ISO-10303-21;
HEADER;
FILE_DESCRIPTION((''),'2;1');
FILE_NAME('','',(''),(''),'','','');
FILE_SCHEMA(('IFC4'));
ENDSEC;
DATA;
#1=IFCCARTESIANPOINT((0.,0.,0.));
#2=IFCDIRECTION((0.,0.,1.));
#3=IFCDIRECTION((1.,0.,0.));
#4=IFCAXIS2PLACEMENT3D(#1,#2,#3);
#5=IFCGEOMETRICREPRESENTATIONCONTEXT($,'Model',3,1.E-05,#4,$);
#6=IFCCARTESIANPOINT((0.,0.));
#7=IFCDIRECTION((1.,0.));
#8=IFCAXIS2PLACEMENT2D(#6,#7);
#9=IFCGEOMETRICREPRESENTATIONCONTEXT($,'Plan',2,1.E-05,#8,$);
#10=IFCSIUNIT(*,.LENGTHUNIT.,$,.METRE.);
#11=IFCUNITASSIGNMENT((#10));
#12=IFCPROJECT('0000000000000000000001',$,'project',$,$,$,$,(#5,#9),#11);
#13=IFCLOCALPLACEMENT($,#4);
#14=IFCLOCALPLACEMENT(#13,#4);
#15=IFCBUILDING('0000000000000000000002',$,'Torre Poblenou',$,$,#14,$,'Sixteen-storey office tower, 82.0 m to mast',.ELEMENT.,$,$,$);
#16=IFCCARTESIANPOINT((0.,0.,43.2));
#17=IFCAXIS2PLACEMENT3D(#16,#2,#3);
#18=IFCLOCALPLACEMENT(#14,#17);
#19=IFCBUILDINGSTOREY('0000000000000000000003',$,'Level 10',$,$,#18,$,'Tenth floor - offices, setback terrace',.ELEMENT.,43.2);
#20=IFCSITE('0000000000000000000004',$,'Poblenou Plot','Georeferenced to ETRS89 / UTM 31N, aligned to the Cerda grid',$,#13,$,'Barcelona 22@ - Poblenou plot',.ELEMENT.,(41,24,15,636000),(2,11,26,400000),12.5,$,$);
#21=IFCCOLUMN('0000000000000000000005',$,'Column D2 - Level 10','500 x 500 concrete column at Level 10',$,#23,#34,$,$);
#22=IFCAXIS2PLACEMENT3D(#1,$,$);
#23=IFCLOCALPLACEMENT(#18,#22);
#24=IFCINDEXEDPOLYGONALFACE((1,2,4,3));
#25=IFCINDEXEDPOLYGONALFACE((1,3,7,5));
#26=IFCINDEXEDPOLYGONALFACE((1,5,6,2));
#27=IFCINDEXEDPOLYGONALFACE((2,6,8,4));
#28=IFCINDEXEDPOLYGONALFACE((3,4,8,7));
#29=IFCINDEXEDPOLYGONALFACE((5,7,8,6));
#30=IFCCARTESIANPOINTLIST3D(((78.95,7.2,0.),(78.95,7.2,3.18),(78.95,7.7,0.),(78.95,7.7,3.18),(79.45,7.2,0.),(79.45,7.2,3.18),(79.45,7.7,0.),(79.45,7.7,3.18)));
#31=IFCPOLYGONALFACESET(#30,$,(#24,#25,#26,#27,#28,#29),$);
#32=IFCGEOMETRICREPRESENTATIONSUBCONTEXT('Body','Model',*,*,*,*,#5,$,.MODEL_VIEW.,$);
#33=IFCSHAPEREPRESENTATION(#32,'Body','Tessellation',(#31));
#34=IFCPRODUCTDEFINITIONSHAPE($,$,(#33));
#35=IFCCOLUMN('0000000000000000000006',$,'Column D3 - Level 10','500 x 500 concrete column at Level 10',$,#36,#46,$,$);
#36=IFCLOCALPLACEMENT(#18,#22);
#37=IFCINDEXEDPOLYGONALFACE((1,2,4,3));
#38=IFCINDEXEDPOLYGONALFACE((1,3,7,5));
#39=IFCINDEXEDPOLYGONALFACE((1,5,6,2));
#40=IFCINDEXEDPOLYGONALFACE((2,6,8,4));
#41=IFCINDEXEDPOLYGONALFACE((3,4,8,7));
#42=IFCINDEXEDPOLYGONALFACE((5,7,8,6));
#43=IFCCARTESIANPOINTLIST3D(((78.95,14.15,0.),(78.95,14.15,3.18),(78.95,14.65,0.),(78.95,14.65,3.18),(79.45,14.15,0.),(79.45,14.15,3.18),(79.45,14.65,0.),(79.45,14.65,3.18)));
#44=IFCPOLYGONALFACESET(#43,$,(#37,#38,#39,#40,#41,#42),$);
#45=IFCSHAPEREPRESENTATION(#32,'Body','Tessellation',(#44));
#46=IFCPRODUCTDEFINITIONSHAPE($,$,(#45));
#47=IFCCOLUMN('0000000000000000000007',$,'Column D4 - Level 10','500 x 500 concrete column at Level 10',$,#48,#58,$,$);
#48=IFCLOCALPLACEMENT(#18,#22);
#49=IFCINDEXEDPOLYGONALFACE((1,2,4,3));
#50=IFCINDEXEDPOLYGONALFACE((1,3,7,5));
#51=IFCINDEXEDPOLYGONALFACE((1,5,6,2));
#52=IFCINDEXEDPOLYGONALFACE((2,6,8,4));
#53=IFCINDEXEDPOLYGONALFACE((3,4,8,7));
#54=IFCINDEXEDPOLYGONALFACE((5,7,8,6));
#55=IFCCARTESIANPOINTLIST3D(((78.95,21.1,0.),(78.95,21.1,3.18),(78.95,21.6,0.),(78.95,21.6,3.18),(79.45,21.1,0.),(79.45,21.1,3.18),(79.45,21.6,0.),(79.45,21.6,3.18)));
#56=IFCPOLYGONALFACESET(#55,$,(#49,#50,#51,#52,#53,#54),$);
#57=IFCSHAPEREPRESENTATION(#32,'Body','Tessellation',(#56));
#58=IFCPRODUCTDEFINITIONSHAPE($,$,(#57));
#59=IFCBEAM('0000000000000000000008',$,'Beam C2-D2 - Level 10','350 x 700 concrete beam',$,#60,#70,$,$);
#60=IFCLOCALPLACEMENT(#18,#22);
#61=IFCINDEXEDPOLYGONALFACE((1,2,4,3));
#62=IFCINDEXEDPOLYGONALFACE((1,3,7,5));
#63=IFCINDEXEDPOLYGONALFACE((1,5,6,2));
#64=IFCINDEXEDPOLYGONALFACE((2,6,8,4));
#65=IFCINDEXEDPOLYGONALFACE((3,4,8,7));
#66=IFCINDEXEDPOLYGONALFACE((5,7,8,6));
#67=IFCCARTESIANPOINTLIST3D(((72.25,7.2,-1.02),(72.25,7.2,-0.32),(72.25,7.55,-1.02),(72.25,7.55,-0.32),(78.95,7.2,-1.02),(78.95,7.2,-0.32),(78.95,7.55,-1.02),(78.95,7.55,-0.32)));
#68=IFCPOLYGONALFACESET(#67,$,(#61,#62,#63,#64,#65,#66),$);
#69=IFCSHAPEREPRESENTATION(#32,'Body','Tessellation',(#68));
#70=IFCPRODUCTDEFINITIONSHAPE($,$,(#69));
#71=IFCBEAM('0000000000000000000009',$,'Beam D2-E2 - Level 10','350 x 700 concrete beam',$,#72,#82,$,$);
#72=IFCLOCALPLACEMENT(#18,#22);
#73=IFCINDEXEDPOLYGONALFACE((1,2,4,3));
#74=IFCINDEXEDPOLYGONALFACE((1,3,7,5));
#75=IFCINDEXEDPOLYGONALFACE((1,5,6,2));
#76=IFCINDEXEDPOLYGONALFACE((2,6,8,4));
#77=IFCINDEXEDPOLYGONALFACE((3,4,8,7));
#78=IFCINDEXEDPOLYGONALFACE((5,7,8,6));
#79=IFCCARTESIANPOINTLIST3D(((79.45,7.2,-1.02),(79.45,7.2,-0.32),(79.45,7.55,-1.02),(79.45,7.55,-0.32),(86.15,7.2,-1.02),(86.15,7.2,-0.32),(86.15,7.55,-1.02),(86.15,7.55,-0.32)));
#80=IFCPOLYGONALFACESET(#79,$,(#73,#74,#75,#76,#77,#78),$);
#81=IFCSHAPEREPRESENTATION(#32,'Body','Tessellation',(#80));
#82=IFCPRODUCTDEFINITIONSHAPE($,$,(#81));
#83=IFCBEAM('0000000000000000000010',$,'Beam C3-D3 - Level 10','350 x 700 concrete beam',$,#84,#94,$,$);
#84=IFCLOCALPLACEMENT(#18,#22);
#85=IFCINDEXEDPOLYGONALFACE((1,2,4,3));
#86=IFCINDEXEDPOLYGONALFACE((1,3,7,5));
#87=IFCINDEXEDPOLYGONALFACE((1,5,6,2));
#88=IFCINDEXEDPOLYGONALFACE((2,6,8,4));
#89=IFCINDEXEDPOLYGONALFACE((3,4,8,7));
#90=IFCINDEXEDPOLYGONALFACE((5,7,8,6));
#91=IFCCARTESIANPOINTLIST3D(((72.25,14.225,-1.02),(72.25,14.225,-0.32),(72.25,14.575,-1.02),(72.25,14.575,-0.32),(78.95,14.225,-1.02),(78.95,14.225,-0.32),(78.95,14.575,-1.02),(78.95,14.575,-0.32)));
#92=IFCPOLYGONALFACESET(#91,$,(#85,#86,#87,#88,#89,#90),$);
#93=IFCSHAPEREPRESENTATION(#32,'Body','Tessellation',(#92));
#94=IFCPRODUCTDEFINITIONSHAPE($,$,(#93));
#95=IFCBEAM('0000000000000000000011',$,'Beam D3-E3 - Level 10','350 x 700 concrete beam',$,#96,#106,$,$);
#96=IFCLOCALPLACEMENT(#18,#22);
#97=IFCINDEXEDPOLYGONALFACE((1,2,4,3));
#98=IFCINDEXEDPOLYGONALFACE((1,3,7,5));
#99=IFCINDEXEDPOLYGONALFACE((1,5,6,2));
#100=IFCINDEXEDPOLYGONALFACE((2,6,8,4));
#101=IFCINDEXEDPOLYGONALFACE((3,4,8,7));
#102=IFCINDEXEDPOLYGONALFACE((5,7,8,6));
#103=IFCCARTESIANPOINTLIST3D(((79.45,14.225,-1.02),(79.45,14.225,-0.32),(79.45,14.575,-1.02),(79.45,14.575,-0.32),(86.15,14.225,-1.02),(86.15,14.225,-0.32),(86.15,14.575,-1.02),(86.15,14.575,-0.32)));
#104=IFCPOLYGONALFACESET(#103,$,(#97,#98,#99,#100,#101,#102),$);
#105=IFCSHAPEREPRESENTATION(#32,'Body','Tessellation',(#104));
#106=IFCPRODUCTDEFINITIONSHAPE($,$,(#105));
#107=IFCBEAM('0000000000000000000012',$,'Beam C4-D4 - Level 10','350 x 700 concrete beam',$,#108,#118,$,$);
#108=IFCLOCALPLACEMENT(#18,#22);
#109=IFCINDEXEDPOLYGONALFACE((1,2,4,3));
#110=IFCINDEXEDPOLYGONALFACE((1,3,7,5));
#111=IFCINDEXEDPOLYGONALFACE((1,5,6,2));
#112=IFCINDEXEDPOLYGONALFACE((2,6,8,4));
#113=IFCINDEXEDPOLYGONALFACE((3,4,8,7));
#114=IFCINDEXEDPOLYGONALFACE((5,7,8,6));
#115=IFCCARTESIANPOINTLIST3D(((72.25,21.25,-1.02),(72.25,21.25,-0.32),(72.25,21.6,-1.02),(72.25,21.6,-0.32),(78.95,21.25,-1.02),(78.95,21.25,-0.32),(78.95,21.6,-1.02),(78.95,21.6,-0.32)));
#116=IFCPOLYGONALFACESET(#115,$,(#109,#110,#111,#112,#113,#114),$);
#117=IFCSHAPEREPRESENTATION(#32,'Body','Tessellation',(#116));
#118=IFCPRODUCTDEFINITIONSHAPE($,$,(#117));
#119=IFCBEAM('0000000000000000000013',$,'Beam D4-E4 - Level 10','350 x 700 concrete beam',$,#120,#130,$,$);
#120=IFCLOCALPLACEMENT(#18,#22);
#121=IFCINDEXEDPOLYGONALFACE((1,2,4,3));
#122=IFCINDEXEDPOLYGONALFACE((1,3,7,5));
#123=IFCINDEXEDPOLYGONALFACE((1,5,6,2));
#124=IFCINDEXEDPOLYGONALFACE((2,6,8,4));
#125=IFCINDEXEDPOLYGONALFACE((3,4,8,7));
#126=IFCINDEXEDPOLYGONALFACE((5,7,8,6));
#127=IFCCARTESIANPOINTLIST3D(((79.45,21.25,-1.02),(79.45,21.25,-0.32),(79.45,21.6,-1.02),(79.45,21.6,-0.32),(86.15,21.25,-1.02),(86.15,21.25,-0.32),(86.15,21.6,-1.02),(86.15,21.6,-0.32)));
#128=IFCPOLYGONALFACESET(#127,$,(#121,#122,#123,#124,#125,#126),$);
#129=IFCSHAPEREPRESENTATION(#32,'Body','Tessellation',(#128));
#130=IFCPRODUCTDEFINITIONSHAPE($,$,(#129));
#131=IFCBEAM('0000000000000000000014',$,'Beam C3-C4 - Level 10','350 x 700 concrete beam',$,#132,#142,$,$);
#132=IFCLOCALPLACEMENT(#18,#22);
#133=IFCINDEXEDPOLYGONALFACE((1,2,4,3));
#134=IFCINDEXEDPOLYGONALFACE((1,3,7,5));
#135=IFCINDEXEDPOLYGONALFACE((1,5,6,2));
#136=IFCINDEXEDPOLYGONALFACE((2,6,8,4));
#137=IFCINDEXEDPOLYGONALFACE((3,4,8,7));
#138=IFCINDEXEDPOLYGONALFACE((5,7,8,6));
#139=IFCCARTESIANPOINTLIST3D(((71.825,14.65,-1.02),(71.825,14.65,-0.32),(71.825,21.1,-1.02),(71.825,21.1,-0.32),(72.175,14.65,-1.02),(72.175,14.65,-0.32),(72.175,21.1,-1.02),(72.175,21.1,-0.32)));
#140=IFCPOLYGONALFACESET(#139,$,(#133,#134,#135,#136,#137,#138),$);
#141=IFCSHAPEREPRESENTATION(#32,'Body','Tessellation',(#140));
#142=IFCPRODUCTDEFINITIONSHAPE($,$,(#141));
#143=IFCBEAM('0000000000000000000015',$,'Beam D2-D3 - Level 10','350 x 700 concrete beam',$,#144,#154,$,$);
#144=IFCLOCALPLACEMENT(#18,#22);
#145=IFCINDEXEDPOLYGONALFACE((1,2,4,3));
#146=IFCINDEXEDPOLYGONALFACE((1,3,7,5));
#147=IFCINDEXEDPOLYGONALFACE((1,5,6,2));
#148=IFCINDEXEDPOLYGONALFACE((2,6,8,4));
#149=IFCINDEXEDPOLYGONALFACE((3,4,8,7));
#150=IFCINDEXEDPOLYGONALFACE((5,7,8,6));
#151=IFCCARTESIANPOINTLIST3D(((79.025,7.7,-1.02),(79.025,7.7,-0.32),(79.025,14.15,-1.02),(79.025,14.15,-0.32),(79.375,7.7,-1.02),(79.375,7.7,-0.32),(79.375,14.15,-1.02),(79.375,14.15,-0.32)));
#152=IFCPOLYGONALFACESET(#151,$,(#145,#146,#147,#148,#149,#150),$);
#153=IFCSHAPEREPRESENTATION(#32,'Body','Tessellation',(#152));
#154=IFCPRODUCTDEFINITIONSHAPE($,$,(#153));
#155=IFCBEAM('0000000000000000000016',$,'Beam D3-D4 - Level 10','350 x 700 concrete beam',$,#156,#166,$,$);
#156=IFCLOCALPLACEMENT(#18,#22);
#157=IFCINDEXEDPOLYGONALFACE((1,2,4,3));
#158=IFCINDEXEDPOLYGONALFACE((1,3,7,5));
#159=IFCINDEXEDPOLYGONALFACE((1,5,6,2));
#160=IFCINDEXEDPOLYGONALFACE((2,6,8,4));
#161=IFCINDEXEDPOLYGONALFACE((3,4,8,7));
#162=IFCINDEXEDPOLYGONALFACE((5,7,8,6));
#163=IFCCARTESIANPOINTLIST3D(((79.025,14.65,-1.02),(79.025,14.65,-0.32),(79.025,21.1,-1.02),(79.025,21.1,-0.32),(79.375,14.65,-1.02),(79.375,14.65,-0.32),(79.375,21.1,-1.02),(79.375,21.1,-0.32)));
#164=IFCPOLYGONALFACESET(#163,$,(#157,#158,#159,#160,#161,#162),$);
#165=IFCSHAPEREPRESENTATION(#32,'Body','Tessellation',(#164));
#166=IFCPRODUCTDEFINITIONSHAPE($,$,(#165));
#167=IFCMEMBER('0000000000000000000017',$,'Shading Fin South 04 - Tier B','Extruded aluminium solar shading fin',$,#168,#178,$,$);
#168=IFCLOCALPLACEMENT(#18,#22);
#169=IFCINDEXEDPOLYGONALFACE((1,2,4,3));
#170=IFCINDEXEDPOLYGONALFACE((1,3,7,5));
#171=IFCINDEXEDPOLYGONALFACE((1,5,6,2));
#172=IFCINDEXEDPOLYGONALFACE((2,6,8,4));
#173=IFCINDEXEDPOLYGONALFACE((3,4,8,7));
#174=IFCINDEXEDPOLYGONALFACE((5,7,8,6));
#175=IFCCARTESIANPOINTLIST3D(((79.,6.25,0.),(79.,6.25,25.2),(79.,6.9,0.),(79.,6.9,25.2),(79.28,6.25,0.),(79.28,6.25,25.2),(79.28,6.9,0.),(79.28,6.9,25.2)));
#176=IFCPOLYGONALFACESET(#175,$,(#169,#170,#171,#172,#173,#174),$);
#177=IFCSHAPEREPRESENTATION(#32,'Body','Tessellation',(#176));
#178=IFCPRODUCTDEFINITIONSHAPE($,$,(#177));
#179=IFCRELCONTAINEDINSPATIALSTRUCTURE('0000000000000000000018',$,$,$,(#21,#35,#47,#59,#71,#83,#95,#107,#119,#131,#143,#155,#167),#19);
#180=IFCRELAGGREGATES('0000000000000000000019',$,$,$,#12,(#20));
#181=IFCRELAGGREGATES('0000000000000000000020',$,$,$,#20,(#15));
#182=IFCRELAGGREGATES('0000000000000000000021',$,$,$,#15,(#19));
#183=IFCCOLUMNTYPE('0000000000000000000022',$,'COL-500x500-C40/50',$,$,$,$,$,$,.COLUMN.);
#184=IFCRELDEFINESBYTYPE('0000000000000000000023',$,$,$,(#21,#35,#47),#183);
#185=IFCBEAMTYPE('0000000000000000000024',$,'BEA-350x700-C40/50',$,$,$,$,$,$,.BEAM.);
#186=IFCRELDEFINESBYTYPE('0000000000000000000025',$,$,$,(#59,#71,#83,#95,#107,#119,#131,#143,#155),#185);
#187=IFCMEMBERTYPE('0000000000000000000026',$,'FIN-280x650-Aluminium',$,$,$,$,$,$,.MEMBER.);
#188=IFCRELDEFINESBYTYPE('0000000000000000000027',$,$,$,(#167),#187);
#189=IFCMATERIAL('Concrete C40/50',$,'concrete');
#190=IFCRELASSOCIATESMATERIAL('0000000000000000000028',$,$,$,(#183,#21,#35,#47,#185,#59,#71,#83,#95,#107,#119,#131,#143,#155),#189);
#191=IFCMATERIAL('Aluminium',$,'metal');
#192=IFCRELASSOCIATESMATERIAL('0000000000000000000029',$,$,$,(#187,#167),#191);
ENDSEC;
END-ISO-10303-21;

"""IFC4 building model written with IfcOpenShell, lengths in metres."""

from ifc_helpers import new_model, si_unit, frame, origin_with_axes, origin_2d_with_axis, place, context, subcontext, project, spatial, line, indexed_curve, rectangle, outline, extrude, material, material_profile, profile_set, profile_usage, type_object, element, save


model = new_model("IFC4")

# Units and contexts
model_context = context("Model", 3, precision=1e-05, world=origin_with_axes())
plan_context = context("Plan", 2, precision=1e-05, world=origin_2d_with_axis())
body_context = subcontext(model_context, "Body", "Model", "MODEL_VIEW")
ifc_project = project(units=[si_unit("LENGTHUNIT", "METRE")], contexts=[model_context, plan_context])

# Site, building, storey
site_placement = place(None, origin_with_axes())
site = spatial("IfcSite", under=ifc_project, at=site_placement, Name="Poblenou Plot", Description="Georeferenced to ETRS89 / UTM 31N, aligned to the Cerda grid", LongName="Barcelona 22@ - Poblenou plot", CompositionType="ELEMENT", RefLatitude=(41, 24, 15, 636000), RefLongitude=(2, 11, 26, 400000), RefElevation=12.5)
building_placement = place(site_placement, origin_with_axes())
building = spatial("IfcBuilding", under=site, at=building_placement, Name="Torre Poblenou", LongName="Sixteen-storey office tower, 82.0 m to mast", CompositionType="ELEMENT")
storey_placement = place(building_placement, frame((0.0, 0.0, 43.2), z_axis=(0.0, 0.0, 1.0), x_axis=(1.0, 0.0, 0.0)))
storey = spatial("IfcBuildingStorey", under=building, at=storey_placement, Name="Level 10", LongName="Tenth floor - offices, setback terrace", CompositionType="ELEMENT", Elevation=43.2)

# Columns
ifc_material_1 = material(Name="Concrete C40/50", Category="concrete")
ifc_material_profile_1 = material_profile(ifc_material_1, rectangle(XDim=0.5, YDim=0.5))
ifc_profile_set_1 = profile_set([ifc_material_profile_1], Name="COL-500x500-C40/50")
ifc_profile_usage_1 = profile_usage(ifc_profile_set_1)
column_type = type_object("IfcColumnType", Name="COL-500x500-C40/50", PredefinedType="COLUMN", material=ifc_profile_set_1)
column_1_placement = place(storey_placement, frame((78.95, 7.2, 0.0), z_axis=(0.0, 0.0, 1.0), x_axis=(1.0, 0.0, 0.0)))
element("IfcColumn", 1, at=column_1_placement, inside=storey, type_object=column_type, material=ifc_profile_usage_1, Name="Column D2 - Level 10", Description="500 x 500 concrete column at Level 10", context=body_context, shape_type="SweptSolid", body=[
    extrude(outline(indexed_curve([(0.0, 0.0), (0.5, 0.0), (0.5, 0.5), (0.0, 0.5)], segments=[line(1, 2, 3, 4, 1)])), origin_with_axes(), (0.0, 0.0, 1.0), 3.18),
])
ifc_profile_usage_2 = profile_usage(ifc_profile_set_1)
column_2_placement = place(storey_placement, frame((78.95, 14.15, 0.0), z_axis=(0.0, 0.0, 1.0), x_axis=(1.0, 0.0, 0.0)))
element("IfcColumn", 2, at=column_2_placement, inside=storey, type_object=column_type, material=ifc_profile_usage_2, Name="Column D3 - Level 10", Description="500 x 500 concrete column at Level 10", context=body_context, shape_type="SweptSolid", body=[
    extrude(outline(indexed_curve([(0.0, 0.0), (0.5, 0.0), (0.5, 0.5), (0.0, 0.5)], segments=[line(1, 2, 3, 4, 1)])), origin_with_axes(), (0.0, 0.0, 1.0), 3.18),
])
ifc_profile_usage_3 = profile_usage(ifc_profile_set_1)
column_3_placement = place(storey_placement, frame((78.95, 21.1, 0.0), z_axis=(0.0, 0.0, 1.0), x_axis=(1.0, 0.0, 0.0)))
element("IfcColumn", 3, at=column_3_placement, inside=storey, type_object=column_type, material=ifc_profile_usage_3, Name="Column D4 - Level 10", Description="500 x 500 concrete column at Level 10", context=body_context, shape_type="SweptSolid", body=[
    extrude(outline(indexed_curve([(0.0, 0.0), (0.5, 0.0), (0.5, 0.5), (0.0, 0.5)], segments=[line(1, 2, 3, 4, 1)])), origin_with_axes(), (0.0, 0.0, 1.0), 3.18),
])

# Beams
ifc_material_profile_2 = material_profile(ifc_material_1, rectangle(XDim=0.35, YDim=0.7))
ifc_profile_set_2 = profile_set([ifc_material_profile_2], Name="BEA-350x700-C40/50")
ifc_profile_usage_4 = profile_usage(ifc_profile_set_2)
beam_type = type_object("IfcBeamType", Name="BEA-350x700-C40/50", PredefinedType="BEAM", material=ifc_profile_set_2)
beam_1_placement = place(storey_placement, frame((72.25, 7.2, -1.02), z_axis=(0.0, 0.0, 1.0), x_axis=(1.0, 0.0, 0.0)))
element("IfcBeam", 4, at=beam_1_placement, inside=storey, type_object=beam_type, material=ifc_profile_usage_4, Name="Beam C2-D2 - Level 10", Description="350 x 700 concrete beam", context=body_context, shape_type="SweptSolid", body=[
    extrude(outline(indexed_curve([(0.0, 0.0), (6.7, 0.0), (6.7, 0.35), (0.0, 0.35)], segments=[line(1, 2, 3, 4, 1)])), origin_with_axes(), (0.0, 0.0, 1.0), 0.7),
])
ifc_profile_usage_5 = profile_usage(ifc_profile_set_2)
beam_2_placement = place(storey_placement, frame((79.45, 7.2, -1.02), z_axis=(0.0, 0.0, 1.0), x_axis=(1.0, 0.0, 0.0)))
element("IfcBeam", 5, at=beam_2_placement, inside=storey, type_object=beam_type, material=ifc_profile_usage_5, Name="Beam D2-E2 - Level 10", Description="350 x 700 concrete beam", context=body_context, shape_type="SweptSolid", body=[
    extrude(outline(indexed_curve([(0.0, 0.0), (6.7, 0.0), (6.7, 0.35), (0.0, 0.35)], segments=[line(1, 2, 3, 4, 1)])), origin_with_axes(), (0.0, 0.0, 1.0), 0.7),
])
ifc_profile_usage_6 = profile_usage(ifc_profile_set_2)
beam_3_placement = place(storey_placement, frame((72.25, 14.225, -1.02), z_axis=(0.0, 0.0, 1.0), x_axis=(1.0, 0.0, 0.0)))
element("IfcBeam", 6, at=beam_3_placement, inside=storey, type_object=beam_type, material=ifc_profile_usage_6, Name="Beam C3-D3 - Level 10", Description="350 x 700 concrete beam", context=body_context, shape_type="SweptSolid", body=[
    extrude(outline(indexed_curve([(0.0, 0.0), (6.7, 0.0), (6.7, 0.35), (0.0, 0.35)], segments=[line(1, 2, 3, 4, 1)])), origin_with_axes(), (0.0, 0.0, 1.0), 0.7),
])
ifc_profile_usage_7 = profile_usage(ifc_profile_set_2)
beam_4_placement = place(storey_placement, frame((79.45, 14.225, -1.02), z_axis=(0.0, 0.0, 1.0), x_axis=(1.0, 0.0, 0.0)))
element("IfcBeam", 7, at=beam_4_placement, inside=storey, type_object=beam_type, material=ifc_profile_usage_7, Name="Beam D3-E3 - Level 10", Description="350 x 700 concrete beam", context=body_context, shape_type="SweptSolid", body=[
    extrude(outline(indexed_curve([(0.0, 0.0), (6.7, 0.0), (6.7, 0.35), (0.0, 0.35)], segments=[line(1, 2, 3, 4, 1)])), origin_with_axes(), (0.0, 0.0, 1.0), 0.7),
])
ifc_profile_usage_8 = profile_usage(ifc_profile_set_2)
beam_5_placement = place(storey_placement, frame((72.25, 21.25, -1.02), z_axis=(0.0, 0.0, 1.0), x_axis=(1.0, 0.0, 0.0)))
element("IfcBeam", 8, at=beam_5_placement, inside=storey, type_object=beam_type, material=ifc_profile_usage_8, Name="Beam C4-D4 - Level 10", Description="350 x 700 concrete beam", context=body_context, shape_type="SweptSolid", body=[
    extrude(outline(indexed_curve([(0.0, 0.0), (6.7, 0.0), (6.7, 0.35), (0.0, 0.35)], segments=[line(1, 2, 3, 4, 1)])), origin_with_axes(), (0.0, 0.0, 1.0), 0.7),
])
ifc_profile_usage_9 = profile_usage(ifc_profile_set_2)
beam_6_placement = place(storey_placement, frame((79.45, 21.25, -1.02), z_axis=(0.0, 0.0, 1.0), x_axis=(1.0, 0.0, 0.0)))
element("IfcBeam", 9, at=beam_6_placement, inside=storey, type_object=beam_type, material=ifc_profile_usage_9, Name="Beam D4-E4 - Level 10", Description="350 x 700 concrete beam", context=body_context, shape_type="SweptSolid", body=[
    extrude(outline(indexed_curve([(0.0, 0.0), (6.7, 0.0), (6.7, 0.35), (0.0, 0.35)], segments=[line(1, 2, 3, 4, 1)])), origin_with_axes(), (0.0, 0.0, 1.0), 0.7),
])
ifc_profile_usage_10 = profile_usage(ifc_profile_set_2)
beam_7_placement = place(storey_placement, frame((72.175, 14.65, -1.02), z_axis=(0.0, 0.0, 1.0), x_axis=(0.0, 1.0, 0.0)))
element("IfcBeam", 10, at=beam_7_placement, inside=storey, type_object=beam_type, material=ifc_profile_usage_10, Name="Beam C3-C4 - Level 10", Description="350 x 700 concrete beam", context=body_context, shape_type="SweptSolid", body=[
    extrude(outline(indexed_curve([(0.0, 0.0), (6.45, 0.0), (6.45, 0.35), (0.0, 0.35)], segments=[line(1, 2, 3, 4, 1)])), origin_with_axes(), (0.0, 0.0, 1.0), 0.7),
])
ifc_profile_usage_11 = profile_usage(ifc_profile_set_2)
beam_8_placement = place(storey_placement, frame((79.375, 7.7, -1.02), z_axis=(0.0, 0.0, 1.0), x_axis=(0.0, 1.0, 0.0)))
element("IfcBeam", 11, at=beam_8_placement, inside=storey, type_object=beam_type, material=ifc_profile_usage_11, Name="Beam D2-D3 - Level 10", Description="350 x 700 concrete beam", context=body_context, shape_type="SweptSolid", body=[
    extrude(outline(indexed_curve([(0.0, 0.0), (6.45, 0.0), (6.45, 0.35), (0.0, 0.35)], segments=[line(1, 2, 3, 4, 1)])), origin_with_axes(), (0.0, 0.0, 1.0), 0.7),
])
ifc_profile_usage_12 = profile_usage(ifc_profile_set_2)
beam_9_placement = place(storey_placement, frame((79.375, 14.65, -1.02), z_axis=(0.0, 0.0, 1.0), x_axis=(0.0, 1.0, 0.0)))
element("IfcBeam", 12, at=beam_9_placement, inside=storey, type_object=beam_type, material=ifc_profile_usage_12, Name="Beam D3-D4 - Level 10", Description="350 x 700 concrete beam", context=body_context, shape_type="SweptSolid", body=[
    extrude(outline(indexed_curve([(0.0, 0.0), (6.45, 0.0), (6.45, 0.35), (0.0, 0.35)], segments=[line(1, 2, 3, 4, 1)])), origin_with_axes(), (0.0, 0.0, 1.0), 0.7),
])

# Member
ifc_material_2 = material(Name="Aluminium", Category="metal")
ifc_material_profile_3 = material_profile(ifc_material_2, rectangle(XDim=0.28, YDim=0.65))
ifc_profile_set_3 = profile_set([ifc_material_profile_3], Name="FIN-280x650-Aluminium")
ifc_profile_usage_13 = profile_usage(ifc_profile_set_3)
member_type = type_object("IfcMemberType", Name="FIN-280x650-Aluminium", PredefinedType="MEMBER", material=ifc_profile_set_3)
member_1_placement = place(storey_placement, frame((79.28, 6.9, 0.0), z_axis=(0.0, 0.0, 1.0), x_axis=(-1.0, 0.0, 0.0)))
element("IfcMember", 13, at=member_1_placement, inside=storey, type_object=member_type, material=ifc_profile_usage_13, Name="Shading Fin South 04 - Tier B", Description="Extruded aluminium solar shading fin", context=body_context, shape_type="SweptSolid", body=[
    extrude(outline(indexed_curve([(0.0, 0.0), (0.28, 0.0), (0.28, 0.65), (0.0, 0.65)], segments=[line(1, 2, 3, 4, 1)])), origin_with_axes(), (0.0, 0.0, 1.0), 25.2),
])

save(model, "model.ifc")
